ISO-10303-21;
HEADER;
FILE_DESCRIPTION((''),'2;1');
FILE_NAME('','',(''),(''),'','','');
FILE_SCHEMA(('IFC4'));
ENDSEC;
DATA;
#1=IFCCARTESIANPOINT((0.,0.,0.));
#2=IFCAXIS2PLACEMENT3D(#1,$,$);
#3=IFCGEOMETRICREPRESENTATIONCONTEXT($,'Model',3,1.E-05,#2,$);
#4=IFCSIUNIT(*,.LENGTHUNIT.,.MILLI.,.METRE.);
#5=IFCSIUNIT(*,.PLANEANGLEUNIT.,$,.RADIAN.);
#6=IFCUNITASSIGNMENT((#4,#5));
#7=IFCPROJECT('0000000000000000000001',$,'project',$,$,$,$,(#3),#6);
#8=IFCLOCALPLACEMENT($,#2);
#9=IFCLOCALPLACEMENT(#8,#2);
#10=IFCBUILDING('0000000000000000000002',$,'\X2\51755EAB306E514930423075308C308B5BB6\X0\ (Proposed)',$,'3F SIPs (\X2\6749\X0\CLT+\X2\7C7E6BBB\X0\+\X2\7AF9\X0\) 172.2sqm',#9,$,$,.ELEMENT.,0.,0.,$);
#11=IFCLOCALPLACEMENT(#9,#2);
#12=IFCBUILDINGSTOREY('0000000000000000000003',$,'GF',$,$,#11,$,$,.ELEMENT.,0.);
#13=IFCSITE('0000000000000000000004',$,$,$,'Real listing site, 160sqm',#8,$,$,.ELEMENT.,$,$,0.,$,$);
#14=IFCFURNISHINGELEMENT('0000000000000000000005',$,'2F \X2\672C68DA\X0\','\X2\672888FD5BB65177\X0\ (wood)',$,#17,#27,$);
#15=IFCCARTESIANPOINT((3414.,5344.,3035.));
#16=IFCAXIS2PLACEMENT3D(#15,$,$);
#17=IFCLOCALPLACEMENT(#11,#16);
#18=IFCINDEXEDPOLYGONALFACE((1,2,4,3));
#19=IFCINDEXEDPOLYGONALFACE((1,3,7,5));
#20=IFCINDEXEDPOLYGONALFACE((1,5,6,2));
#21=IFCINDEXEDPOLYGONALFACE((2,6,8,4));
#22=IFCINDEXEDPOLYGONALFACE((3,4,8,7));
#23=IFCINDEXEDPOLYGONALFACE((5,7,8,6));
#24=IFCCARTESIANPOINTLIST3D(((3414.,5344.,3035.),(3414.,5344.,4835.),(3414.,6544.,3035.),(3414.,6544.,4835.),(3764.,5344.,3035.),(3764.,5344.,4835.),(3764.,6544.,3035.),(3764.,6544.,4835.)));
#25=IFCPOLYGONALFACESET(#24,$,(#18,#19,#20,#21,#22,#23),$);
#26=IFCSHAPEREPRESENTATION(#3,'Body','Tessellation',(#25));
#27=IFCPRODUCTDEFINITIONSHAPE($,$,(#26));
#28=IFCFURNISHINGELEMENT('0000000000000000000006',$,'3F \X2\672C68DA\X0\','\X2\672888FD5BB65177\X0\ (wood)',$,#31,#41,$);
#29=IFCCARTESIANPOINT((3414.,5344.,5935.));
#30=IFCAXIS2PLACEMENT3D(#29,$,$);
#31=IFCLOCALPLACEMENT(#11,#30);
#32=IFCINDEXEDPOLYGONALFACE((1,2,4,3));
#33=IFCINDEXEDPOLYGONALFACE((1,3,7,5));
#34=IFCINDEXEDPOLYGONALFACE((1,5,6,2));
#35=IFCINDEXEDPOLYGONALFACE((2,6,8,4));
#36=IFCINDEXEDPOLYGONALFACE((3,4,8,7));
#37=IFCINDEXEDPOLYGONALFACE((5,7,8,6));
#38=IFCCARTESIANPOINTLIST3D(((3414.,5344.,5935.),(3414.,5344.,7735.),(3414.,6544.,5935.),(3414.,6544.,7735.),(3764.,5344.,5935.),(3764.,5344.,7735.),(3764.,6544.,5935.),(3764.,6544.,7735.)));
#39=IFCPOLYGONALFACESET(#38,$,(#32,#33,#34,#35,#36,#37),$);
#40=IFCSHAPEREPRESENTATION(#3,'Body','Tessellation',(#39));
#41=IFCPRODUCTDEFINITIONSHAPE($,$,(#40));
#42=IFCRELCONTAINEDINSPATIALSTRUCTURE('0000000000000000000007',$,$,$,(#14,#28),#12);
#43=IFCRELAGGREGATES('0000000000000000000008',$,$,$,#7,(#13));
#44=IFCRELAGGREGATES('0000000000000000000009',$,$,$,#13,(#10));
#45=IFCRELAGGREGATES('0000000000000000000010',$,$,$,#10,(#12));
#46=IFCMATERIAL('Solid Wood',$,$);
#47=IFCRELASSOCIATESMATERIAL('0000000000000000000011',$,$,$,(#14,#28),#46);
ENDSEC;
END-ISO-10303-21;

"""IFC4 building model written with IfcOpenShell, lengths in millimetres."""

from ifc_helpers import new_model, si_unit, frame, frame_2d, origin, place, context, project, spatial, rectangle, extrude, material, element, save


model = new_model("IFC4")

# Units and contexts
model_context = context("Model", 3, precision=1e-05, world=origin())
ifc_project = project(units=[si_unit("LENGTHUNIT", "METRE", prefix="MILLI"), si_unit("PLANEANGLEUNIT", "RADIAN")], contexts=[model_context])

# Site, building, storey
site_placement = place(None, origin())
site = spatial("IfcSite", under=ifc_project, at=site_placement, ObjectType="Real listing site, 160sqm", CompositionType="ELEMENT", RefElevation=0.0)
building_placement = place(site_placement, origin())
building = spatial("IfcBuilding", under=site, at=building_placement, Name="兵庫の光あふれる家 (Proposed)", ObjectType="3F SIPs (杉CLT+籾殻+竹) 172.2sqm", CompositionType="ELEMENT", ElevationOfRefHeight=0.0, ElevationOfTerrain=0.0)
storey_placement = place(building_placement, origin())
storey = spatial("IfcBuildingStorey", under=building, at=storey_placement, Name="GF", CompositionType="ELEMENT", Elevation=0.0)

# Shared definitions
ifc_material_1 = material(Name="Solid Wood")

# Furnishing elements
furnishing_1_placement = place(storey_placement, frame((3414.0, 5344.0, 3035.0)))
element("IfcFurnishingElement", 1, at=furnishing_1_placement, inside=storey, material=ifc_material_1, Name="2F 本棚", Description="木製家具 (wood)", context=model_context, shape_type="SweptSolid", body=[
    extrude(rectangle(XDim=350.0, YDim=1200.0, at=frame_2d((175.0, 600.0))), frame((3414.0, 5344.0, 3035.0)), (0.0, 0.0, 1.0), 1800.0),
])
furnishing_2_placement = place(storey_placement, frame((3414.0, 5344.0, 5935.0)))
element("IfcFurnishingElement", 2, at=furnishing_2_placement, inside=storey, material=ifc_material_1, Name="3F 本棚", Description="木製家具 (wood)", context=model_context, shape_type="SweptSolid", body=[
    extrude(rectangle(XDim=350.0, YDim=1200.0, at=frame_2d((175.0, 600.0))), frame((3414.0, 5344.0, 5935.0)), (0.0, 0.0, 1.0), 1800.0),
])

save(model, "model.ifc")
